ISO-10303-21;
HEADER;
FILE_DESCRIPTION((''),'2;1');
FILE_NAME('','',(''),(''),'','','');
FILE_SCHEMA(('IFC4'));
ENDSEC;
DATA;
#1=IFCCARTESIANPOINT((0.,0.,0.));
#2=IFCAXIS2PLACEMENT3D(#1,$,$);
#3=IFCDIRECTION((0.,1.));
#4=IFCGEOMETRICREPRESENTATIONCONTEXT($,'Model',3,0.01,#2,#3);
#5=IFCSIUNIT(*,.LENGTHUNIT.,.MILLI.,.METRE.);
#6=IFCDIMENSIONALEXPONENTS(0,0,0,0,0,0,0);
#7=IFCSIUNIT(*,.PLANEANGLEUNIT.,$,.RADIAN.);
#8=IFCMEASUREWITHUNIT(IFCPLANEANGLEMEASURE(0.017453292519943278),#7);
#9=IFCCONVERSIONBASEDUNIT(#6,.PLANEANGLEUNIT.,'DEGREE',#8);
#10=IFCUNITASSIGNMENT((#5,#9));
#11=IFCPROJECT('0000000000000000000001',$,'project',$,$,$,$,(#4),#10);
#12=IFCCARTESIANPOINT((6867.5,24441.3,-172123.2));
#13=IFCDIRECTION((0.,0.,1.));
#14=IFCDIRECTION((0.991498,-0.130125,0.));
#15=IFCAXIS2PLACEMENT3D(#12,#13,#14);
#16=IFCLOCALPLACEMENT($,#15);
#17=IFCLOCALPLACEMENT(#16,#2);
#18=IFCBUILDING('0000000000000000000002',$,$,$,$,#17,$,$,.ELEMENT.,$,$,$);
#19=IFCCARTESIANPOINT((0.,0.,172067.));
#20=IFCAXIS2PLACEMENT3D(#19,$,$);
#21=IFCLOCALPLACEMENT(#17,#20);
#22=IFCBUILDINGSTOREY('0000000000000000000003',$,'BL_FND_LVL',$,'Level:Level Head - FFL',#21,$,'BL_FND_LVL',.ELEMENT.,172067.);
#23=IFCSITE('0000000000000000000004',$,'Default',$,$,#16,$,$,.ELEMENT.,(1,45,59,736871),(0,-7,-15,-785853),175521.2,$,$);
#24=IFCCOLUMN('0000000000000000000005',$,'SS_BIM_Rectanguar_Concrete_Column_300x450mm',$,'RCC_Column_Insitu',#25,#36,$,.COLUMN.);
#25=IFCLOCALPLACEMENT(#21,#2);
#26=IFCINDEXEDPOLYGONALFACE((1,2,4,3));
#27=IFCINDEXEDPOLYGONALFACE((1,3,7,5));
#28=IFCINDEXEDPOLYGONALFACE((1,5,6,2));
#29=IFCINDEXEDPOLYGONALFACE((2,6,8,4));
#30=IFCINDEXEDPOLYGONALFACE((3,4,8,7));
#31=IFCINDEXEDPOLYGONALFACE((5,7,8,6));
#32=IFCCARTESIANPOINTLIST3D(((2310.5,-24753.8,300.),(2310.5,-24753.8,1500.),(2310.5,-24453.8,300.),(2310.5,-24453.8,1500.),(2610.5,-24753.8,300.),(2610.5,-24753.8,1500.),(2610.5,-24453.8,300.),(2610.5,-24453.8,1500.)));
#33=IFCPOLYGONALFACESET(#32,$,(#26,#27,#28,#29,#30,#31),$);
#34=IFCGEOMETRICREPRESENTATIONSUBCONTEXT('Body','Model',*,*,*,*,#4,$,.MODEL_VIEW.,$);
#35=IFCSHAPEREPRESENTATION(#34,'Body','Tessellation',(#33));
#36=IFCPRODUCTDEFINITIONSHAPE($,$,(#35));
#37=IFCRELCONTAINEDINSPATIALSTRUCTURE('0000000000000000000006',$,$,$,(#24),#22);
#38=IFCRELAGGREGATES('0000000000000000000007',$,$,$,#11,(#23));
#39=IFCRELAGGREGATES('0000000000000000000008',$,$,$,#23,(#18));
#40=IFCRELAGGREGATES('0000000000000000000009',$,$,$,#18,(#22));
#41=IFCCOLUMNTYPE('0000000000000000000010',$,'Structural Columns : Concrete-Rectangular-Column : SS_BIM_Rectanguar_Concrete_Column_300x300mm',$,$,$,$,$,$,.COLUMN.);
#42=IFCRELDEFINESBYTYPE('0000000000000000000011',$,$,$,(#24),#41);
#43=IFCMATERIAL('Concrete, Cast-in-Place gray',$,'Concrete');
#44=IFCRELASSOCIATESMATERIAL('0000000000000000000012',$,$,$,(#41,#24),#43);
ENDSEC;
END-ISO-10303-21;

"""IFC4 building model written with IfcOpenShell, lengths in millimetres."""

from ifc_helpers import new_model, entity, si_unit, converted_unit, direction, frame, origin, place, context, subcontext, project, spatial, indexed_curve, outline, extrude, source, transform, mapped, material, type_object, type_shapes, element, save


model = new_model("IFC4")

# Units and contexts
model_context = context("Model", 3, precision=0.01, world=origin(), true_north=direction((0.0, 1.0)))
body_context = subcontext(model_context, "Body", "Model", "MODEL_VIEW")
ifc_project = project(units=[si_unit("LENGTHUNIT", "METRE", prefix="MILLI"), converted_unit("PLANEANGLEUNIT", "DEGREE", entity("IfcPlaneAngleMeasure", 0.017453292519943278), si_unit("PLANEANGLEUNIT", "RADIAN"), dimensions=[0, 0, 0, 0, 0, 0, 0])], contexts=[model_context])

# Site, building, storey
site_placement = place(None, frame((6867.5, 24441.3, -172123.2), z_axis=(0.0, 0.0, 1.0), x_axis=(0.991498, -0.130125, 0.0)))
site = spatial("IfcSite", under=ifc_project, at=site_placement, Name="Default", CompositionType="ELEMENT", RefLatitude=(1, 45, 59, 736871), RefLongitude=(0, -7, -15, -785853), RefElevation=175521.2)
building_placement = place(site_placement, origin())
building = spatial("IfcBuilding", under=site, at=building_placement, CompositionType="ELEMENT")
storey_placement = place(building_placement, frame((0.0, 0.0, 172067.0)))
storey = spatial("IfcBuildingStorey", under=building, at=storey_placement, Name="BL_FND_LVL", ObjectType="Level:Level Head - FFL", LongName="BL_FND_LVL", CompositionType="ELEMENT", Elevation=172067.0)

# Column
ifc_material_1 = material(Name="Concrete, Cast-in-Place gray", Category="Concrete")
column_type_1 = type_object("IfcColumnType", Name="Structural Columns : Concrete-Rectangular-Column : SS_BIM_Rectanguar_Concrete_Column_300x300mm", PredefinedType="COLUMN", material=ifc_material_1)
shared_shape_1 = source(origin(), body_context, "Body", "SweptSolid", [
    extrude(outline(indexed_curve([(-150.0, -150.0), (150.0, -150.0), (150.0, 150.0), (-150.0, 150.0), (-150.0, -150.0)], self_intersect=False)), frame((2460.5, -24603.8, 172367.0), z_axis=(0.0, 0.0, 1.0), x_axis=(-1.0, 0.0, 0.0)), (0.0, 0.0, 1.0), 1200.0),
])
type_shapes(column_type_1, [shared_shape_1])
column_1_placement = place(storey_placement, frame((0.0, 0.0, -172067.0)))
element("IfcColumn", 1, at=column_1_placement, inside=storey, type_object=column_type_1, material=ifc_material_1, Name="SS_BIM_Rectanguar_Concrete_Column_300x450mm", ObjectType="RCC_Column_Insitu", PredefinedType="COLUMN", context=body_context, shape_type="MappedRepresentation", body=[
    mapped(shared_shape_1, transform((0.0, 0.0, 0.0), scale=1.0)),
])

save(model, "model.ifc")
